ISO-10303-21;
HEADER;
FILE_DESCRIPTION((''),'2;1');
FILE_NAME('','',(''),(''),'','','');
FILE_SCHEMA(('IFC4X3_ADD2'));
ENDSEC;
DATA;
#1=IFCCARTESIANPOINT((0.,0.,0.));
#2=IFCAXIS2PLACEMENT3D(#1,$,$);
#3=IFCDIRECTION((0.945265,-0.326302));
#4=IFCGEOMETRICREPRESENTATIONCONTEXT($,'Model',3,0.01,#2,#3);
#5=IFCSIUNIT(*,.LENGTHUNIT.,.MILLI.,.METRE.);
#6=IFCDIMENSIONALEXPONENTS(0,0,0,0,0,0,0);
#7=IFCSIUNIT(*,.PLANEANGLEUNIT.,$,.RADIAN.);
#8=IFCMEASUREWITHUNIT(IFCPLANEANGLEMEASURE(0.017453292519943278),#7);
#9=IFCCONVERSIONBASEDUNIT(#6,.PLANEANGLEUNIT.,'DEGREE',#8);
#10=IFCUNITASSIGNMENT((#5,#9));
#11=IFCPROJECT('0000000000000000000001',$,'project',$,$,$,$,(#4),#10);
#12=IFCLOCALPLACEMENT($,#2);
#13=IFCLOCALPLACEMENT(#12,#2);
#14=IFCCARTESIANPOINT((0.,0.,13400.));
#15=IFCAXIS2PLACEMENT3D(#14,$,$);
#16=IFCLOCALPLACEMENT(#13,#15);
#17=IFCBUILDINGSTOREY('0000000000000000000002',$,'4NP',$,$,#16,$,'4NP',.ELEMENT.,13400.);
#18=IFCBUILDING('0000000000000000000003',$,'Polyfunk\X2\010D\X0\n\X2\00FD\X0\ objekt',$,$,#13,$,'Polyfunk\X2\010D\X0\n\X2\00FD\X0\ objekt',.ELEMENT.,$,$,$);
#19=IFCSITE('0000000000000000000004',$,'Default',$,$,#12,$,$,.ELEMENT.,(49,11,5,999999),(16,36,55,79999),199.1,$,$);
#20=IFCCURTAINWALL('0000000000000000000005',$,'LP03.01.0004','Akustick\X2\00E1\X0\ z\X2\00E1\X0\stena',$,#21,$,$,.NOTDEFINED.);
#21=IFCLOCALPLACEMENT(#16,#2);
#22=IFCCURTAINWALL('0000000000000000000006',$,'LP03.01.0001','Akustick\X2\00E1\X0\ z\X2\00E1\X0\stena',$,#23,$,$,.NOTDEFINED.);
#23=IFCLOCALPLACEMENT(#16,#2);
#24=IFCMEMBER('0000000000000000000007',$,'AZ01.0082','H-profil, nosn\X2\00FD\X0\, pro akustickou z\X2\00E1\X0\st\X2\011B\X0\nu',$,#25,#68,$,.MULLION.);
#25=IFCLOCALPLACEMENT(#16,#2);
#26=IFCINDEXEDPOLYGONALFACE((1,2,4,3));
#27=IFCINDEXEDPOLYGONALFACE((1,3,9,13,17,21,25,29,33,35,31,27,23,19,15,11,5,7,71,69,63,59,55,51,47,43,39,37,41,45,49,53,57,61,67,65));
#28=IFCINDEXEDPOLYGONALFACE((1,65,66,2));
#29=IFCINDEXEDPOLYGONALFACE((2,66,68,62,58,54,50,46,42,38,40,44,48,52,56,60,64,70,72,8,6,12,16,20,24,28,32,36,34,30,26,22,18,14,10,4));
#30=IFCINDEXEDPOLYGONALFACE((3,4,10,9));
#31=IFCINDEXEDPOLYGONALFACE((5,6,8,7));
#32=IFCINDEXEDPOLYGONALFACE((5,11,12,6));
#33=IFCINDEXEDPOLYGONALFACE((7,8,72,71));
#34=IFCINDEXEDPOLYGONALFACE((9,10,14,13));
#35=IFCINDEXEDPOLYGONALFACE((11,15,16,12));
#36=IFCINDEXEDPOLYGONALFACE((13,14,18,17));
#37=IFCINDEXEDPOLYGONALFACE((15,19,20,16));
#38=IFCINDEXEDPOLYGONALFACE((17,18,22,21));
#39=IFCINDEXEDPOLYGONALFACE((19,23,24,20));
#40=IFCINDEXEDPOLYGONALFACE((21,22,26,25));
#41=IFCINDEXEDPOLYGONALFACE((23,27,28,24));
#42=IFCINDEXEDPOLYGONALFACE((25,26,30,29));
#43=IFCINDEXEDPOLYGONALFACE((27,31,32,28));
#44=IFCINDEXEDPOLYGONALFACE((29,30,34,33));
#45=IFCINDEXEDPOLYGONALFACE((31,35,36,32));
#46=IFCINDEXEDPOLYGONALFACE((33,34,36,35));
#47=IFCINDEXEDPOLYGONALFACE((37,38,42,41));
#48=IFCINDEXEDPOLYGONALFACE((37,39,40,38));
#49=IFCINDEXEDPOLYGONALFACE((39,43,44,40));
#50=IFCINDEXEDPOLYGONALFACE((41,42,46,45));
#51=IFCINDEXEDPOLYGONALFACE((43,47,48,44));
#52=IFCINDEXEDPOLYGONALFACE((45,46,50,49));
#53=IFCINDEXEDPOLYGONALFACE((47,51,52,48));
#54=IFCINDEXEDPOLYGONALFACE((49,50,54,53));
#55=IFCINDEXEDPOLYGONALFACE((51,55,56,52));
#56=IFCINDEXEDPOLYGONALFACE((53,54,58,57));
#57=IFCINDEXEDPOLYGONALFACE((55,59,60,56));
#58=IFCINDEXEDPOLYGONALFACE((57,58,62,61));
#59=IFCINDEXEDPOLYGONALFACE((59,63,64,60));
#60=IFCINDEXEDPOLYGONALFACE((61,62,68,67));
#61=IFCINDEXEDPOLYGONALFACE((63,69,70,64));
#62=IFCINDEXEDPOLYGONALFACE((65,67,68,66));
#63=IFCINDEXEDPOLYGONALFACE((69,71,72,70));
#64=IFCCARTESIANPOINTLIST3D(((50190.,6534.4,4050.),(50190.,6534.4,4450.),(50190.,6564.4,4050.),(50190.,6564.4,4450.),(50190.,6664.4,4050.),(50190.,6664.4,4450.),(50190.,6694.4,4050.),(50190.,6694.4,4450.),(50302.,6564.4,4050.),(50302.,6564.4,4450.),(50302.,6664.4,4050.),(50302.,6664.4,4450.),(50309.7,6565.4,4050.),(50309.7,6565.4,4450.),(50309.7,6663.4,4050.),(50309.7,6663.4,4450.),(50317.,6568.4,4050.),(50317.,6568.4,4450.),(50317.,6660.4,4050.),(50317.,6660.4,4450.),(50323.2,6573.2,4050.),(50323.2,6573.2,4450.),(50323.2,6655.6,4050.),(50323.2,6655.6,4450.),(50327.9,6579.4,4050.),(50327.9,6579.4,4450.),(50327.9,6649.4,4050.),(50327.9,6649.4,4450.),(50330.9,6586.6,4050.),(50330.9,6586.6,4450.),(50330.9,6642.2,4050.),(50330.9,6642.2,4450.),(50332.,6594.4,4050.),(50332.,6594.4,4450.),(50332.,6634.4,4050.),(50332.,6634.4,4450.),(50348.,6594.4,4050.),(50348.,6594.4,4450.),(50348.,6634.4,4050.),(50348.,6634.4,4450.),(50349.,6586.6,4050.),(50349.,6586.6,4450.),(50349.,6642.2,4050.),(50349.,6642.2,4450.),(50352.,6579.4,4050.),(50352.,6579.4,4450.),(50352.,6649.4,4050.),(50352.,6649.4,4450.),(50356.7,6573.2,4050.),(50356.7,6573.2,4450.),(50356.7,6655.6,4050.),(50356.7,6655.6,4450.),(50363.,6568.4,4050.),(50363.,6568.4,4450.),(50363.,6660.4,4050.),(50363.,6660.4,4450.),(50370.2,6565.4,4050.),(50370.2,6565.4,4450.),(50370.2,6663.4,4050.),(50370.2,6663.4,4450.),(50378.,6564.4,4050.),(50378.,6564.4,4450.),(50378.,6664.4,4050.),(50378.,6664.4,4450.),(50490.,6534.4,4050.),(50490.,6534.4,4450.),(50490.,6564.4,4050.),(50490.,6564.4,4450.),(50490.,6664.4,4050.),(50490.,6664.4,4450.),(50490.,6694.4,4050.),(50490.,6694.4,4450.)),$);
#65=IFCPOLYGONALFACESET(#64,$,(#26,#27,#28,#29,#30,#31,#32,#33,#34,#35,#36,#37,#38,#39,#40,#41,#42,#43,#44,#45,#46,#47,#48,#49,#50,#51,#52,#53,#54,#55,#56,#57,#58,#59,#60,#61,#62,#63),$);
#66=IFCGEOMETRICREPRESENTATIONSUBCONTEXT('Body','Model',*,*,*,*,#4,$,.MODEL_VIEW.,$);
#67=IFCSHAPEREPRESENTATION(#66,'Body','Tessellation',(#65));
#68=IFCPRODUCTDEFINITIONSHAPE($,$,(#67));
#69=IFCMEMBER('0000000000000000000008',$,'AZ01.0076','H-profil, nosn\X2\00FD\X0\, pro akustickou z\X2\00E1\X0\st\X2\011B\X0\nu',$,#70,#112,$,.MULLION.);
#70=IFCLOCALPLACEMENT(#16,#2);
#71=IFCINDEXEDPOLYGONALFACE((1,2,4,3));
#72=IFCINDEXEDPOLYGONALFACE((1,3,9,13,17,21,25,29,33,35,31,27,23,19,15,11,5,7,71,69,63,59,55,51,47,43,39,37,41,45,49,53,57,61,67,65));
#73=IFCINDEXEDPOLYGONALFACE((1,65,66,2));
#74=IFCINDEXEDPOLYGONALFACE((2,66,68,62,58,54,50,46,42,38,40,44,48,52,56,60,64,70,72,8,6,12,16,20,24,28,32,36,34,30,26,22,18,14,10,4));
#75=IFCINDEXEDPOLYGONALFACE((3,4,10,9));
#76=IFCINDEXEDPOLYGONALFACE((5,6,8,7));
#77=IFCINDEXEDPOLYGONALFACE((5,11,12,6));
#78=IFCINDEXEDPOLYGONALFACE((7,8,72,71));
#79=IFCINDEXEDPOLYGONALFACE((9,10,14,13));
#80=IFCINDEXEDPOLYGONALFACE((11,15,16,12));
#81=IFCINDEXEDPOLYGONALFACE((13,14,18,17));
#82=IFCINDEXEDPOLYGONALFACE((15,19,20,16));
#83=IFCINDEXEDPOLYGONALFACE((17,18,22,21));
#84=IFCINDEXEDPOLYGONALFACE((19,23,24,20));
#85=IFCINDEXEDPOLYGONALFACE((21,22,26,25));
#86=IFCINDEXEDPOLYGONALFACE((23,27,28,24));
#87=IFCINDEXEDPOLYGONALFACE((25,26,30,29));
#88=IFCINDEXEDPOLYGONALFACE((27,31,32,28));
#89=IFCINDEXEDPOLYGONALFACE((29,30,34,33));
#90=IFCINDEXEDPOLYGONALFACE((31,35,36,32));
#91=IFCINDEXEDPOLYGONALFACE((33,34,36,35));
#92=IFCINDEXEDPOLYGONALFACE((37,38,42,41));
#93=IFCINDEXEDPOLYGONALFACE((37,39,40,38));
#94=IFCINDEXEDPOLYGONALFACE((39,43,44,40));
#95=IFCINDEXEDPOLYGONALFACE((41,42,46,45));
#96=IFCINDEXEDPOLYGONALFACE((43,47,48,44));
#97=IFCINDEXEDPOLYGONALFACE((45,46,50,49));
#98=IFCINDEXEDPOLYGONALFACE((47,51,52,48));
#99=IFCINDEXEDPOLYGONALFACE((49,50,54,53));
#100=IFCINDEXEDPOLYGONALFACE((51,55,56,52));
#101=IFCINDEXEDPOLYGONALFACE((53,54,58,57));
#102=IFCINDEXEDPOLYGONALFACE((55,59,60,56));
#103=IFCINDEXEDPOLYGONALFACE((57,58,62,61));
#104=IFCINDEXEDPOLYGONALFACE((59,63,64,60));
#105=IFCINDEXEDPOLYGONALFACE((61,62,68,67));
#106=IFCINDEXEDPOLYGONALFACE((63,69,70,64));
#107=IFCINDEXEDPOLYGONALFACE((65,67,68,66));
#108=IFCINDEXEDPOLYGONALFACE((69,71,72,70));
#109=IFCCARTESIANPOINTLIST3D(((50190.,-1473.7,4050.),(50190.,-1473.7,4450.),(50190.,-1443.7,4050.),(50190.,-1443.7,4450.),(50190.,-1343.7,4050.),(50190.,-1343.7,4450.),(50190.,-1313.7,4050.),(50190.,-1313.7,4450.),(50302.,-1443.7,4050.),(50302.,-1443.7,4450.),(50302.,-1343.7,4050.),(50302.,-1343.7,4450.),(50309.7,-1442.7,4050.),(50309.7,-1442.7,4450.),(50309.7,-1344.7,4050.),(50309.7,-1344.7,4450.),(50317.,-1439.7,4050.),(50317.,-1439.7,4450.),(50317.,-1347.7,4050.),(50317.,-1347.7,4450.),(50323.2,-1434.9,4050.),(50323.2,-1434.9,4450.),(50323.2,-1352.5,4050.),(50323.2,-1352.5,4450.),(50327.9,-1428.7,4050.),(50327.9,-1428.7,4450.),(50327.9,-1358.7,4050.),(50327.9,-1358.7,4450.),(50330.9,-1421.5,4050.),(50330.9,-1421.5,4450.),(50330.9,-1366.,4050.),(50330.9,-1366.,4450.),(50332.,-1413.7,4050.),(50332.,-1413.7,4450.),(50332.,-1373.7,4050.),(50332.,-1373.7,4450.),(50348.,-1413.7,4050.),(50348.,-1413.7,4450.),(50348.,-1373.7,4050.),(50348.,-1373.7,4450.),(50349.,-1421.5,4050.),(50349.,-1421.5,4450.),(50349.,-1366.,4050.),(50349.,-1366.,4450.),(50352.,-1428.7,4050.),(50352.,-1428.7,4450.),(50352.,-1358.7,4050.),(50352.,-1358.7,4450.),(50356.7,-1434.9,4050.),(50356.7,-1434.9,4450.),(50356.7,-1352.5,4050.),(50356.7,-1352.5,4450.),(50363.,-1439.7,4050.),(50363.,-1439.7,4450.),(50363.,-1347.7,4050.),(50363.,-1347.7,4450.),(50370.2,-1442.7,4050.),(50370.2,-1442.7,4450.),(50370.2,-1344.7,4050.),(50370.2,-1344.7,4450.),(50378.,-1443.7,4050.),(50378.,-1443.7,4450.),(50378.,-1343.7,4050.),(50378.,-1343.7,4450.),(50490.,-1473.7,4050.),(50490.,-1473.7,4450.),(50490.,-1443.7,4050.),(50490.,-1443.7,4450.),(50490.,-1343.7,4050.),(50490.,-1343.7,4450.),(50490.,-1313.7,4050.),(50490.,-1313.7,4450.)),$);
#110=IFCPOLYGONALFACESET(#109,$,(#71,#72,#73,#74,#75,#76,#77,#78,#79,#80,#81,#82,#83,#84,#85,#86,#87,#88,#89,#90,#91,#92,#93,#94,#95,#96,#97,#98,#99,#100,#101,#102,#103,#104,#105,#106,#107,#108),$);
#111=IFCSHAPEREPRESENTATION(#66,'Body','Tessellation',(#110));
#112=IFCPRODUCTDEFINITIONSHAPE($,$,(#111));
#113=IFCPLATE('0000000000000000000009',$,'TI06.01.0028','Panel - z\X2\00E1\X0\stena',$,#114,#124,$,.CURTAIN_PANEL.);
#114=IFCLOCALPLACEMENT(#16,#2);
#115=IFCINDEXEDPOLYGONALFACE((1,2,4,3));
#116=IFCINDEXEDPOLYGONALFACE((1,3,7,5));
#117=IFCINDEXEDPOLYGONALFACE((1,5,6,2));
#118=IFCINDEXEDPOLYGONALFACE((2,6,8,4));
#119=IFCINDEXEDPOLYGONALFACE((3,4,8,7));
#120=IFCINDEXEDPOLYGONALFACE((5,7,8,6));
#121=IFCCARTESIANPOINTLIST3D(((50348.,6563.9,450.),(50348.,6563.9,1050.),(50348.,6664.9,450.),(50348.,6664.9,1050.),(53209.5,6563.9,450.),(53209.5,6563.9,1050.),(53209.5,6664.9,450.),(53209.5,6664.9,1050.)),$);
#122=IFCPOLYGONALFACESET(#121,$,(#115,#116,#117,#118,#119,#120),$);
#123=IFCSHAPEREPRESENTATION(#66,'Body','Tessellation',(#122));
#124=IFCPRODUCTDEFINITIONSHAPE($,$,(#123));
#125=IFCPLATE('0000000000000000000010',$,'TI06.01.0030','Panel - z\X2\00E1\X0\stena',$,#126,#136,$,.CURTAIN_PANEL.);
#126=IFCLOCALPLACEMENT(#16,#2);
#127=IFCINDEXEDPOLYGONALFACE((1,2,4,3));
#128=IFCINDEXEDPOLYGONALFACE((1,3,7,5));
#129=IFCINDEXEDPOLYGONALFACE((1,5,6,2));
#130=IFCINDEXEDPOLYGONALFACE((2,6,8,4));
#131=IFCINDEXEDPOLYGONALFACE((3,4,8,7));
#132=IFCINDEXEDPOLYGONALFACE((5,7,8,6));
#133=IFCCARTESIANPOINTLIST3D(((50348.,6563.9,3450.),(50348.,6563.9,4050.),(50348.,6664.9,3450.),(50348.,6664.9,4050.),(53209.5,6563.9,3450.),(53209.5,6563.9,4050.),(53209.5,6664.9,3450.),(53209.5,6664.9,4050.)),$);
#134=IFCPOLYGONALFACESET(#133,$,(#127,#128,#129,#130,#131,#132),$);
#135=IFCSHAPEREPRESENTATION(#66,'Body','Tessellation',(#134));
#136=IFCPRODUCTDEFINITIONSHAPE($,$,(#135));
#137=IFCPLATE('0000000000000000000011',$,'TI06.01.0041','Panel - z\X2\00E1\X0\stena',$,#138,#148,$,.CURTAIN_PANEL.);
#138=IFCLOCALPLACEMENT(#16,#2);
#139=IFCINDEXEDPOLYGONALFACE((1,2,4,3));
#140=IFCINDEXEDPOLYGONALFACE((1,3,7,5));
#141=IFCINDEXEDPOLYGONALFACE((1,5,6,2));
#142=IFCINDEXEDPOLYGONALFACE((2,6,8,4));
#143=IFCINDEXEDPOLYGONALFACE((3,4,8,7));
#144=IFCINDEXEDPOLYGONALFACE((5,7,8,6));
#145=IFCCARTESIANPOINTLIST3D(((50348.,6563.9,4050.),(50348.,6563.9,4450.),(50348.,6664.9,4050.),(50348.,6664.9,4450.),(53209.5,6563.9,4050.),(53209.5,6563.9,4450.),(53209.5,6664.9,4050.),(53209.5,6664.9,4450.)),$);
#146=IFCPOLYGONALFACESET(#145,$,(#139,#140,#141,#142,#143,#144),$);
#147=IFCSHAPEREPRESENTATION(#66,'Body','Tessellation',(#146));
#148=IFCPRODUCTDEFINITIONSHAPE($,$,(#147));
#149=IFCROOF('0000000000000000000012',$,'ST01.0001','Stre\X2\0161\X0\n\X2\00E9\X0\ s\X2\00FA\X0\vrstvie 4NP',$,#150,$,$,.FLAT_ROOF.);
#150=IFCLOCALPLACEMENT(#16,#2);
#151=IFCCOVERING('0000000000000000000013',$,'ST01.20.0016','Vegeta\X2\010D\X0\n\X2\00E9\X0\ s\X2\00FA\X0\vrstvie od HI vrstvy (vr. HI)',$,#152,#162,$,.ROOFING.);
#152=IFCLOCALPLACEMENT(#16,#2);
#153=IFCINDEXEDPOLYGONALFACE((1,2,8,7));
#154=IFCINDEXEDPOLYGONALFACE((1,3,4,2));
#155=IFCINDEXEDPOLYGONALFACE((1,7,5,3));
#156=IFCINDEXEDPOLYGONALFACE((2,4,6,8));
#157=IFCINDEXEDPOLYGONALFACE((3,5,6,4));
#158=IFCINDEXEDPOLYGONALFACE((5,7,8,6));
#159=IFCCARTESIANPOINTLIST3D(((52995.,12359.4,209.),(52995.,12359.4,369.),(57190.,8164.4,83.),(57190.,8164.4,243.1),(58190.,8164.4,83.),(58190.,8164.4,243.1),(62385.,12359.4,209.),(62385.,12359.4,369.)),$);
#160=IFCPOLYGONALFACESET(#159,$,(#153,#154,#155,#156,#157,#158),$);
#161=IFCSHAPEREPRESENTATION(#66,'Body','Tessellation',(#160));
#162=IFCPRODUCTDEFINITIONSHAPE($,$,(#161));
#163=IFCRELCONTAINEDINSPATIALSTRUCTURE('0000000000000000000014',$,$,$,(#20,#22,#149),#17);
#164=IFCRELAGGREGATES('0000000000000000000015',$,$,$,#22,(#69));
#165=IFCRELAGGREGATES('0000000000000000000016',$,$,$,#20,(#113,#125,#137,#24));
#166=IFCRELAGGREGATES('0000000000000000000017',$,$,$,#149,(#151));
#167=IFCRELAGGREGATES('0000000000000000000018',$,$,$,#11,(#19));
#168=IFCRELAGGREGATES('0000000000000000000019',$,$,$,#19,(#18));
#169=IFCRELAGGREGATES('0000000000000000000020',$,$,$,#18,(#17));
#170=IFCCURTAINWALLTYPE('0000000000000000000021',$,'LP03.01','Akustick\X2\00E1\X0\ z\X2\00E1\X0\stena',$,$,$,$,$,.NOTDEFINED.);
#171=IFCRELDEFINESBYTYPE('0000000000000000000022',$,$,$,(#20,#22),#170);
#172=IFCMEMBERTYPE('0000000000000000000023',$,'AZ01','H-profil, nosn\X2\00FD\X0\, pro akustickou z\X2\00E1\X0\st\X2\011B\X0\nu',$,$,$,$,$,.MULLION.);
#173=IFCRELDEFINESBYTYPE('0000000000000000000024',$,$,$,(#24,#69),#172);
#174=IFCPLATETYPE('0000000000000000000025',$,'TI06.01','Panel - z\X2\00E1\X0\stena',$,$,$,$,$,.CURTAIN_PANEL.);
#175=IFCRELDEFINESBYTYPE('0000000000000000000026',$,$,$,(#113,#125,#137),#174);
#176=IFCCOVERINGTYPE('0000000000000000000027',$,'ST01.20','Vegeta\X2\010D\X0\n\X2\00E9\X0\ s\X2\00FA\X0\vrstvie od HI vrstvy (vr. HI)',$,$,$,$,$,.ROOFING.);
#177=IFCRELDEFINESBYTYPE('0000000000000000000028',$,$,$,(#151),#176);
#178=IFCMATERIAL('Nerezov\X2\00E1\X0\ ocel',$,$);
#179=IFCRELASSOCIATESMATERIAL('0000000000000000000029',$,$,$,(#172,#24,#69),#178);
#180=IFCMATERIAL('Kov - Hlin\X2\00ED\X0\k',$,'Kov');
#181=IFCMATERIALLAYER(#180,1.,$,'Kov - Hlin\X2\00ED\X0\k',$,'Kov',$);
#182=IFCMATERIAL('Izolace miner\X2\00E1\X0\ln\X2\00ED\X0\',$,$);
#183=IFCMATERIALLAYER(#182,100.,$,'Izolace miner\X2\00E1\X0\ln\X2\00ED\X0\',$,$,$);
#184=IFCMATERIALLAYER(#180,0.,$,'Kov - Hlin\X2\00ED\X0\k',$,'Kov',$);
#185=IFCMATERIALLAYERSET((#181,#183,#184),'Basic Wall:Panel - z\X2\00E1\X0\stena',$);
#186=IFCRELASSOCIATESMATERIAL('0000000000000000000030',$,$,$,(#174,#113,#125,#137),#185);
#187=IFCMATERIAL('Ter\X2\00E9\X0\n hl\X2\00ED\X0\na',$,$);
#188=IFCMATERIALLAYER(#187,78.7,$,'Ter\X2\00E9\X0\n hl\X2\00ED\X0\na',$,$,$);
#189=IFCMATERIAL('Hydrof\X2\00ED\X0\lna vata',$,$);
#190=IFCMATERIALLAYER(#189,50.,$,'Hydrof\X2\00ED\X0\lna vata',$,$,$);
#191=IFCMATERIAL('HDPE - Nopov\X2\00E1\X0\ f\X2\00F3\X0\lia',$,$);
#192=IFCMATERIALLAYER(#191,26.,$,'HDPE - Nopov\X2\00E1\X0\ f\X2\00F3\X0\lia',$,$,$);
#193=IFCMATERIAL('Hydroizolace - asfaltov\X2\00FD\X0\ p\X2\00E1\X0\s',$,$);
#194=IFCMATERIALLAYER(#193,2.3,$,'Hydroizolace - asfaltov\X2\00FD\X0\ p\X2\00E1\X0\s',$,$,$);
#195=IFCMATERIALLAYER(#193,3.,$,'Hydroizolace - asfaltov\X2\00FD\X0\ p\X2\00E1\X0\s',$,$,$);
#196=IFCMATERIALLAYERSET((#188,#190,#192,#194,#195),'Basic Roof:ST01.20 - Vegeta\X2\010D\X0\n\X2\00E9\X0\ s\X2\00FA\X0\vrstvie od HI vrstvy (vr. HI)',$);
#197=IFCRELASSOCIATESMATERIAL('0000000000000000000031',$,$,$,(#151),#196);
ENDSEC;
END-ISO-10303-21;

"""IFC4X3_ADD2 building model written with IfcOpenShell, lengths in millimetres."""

from ifc_helpers import new_model, entity, si_unit, converted_unit, direction, frame, frame_2d, origin, origin_2d_with_axis, place, context, subcontext, project, spatial, polyline, circle_curve, parameter, trimmed, segment, composite_curve, rectangle, outline, extrude, source, transform, mapped, material, layer, layer_set, layer_usage, material_profile, profile_set, profile_usage, type_object, element, aggregate, save


model = new_model("IFC4X3_ADD2")

# Units and contexts
model_context = context("Model", 3, precision=0.01, world=origin(), true_north=direction((0.945265, -0.326302)))
body_context = subcontext(model_context, "Body", "Model", "MODEL_VIEW")
ifc_project = project(units=[si_unit("LENGTHUNIT", "METRE", prefix="MILLI"), converted_unit("PLANEANGLEUNIT", "DEGREE", entity("IfcPlaneAngleMeasure", 0.017453292519943278), si_unit("PLANEANGLEUNIT", "RADIAN"), dimensions=[0, 0, 0, 0, 0, 0, 0])], contexts=[model_context])

# Site, building, storey
site_placement = place(None, origin())
site = spatial("IfcSite", under=ifc_project, at=site_placement, Name="Default", CompositionType="ELEMENT", RefLatitude=(49, 11, 5, 999999), RefLongitude=(16, 36, 55, 79999), RefElevation=199.1)
building_placement = place(site_placement, origin())
building = spatial("IfcBuilding", under=site, at=building_placement, Name="Polyfunkčný objekt", LongName="Polyfunkčný objekt", CompositionType="ELEMENT")
storey_placement = place(building_placement, frame((0.0, 0.0, 13400.0)))
storey = spatial("IfcBuildingStorey", under=building, at=storey_placement, Name="4NP", LongName="4NP", CompositionType="ELEMENT", Elevation=13400.0)

# Curtain walls
curtain_wall_type = type_object("IfcCurtainWallType", Name="LP03.01", Description="Akustická zástena", PredefinedType="NOTDEFINED")
curtain_wall_1_placement = place(storey_placement, frame((0.0, 0.0, -13400.0)))
curtain_wall_1 = element("IfcCurtainWall", 1, at=curtain_wall_1_placement, inside=storey, type_object=curtain_wall_type, Name="LP03.01.0004", Description="Akustická zástena", PredefinedType="NOTDEFINED")
ifc_material_1 = material(Name="Nerezová ocel")
ifc_material_profile = material_profile(ifc_material_1, outline(composite_curve([segment(polyline([(50.0, -150.0), (80.0, -150.0)]), True, "CONTINUOUS"), segment(polyline([(80.0, -150.0), (80.0, 150.0)]), True, "CONTINUOUS"), segment(polyline([(80.0, 150.0), (50.0, 150.0)]), True, "CONTINUOUS"), segment(polyline([(50.0, 150.0), (50.0, 38.0)]), True, "CONTINUOUS"), segment(trimmed(circle_curve(frame_2d((20.0, 38.0), x_axis=(0.0, 1.0)), 30.0), [parameter(180.0)], [parameter(270.0)], True, "PARAMETER"), False, "CONTINUOUS"), segment(polyline([(20.0, 8.0), (-20.0, 8.0)]), True, "CONTINUOUS"), segment(trimmed(circle_curve(frame_2d((-20.0, 38.0), x_axis=(0.0, 1.0)), 30.0), [parameter(90.0)], [parameter(180.0)], True, "PARAMETER"), False, "CONTINUOUS"), segment(polyline([(-50.0, 38.0), (-50.0, 150.0)]), True, "CONTINUOUS"), segment(polyline([(-50.0, 150.0), (-80.0, 150.0)]), True, "CONTINUOUS"), segment(polyline([(-80.0, 150.0), (-80.0, -150.0)]), True, "CONTINUOUS"), segment(polyline([(-80.0, -150.0), (-50.0, -150.0)]), True, "CONTINUOUS"), segment(polyline([(-50.0, -150.0), (-50.0, -38.0)]), True, "CONTINUOUS"), segment(trimmed(circle_curve(frame_2d((-20.0, -38.0), x_axis=(0.0, 1.0)), 30.0), [parameter(0.0)], [parameter(90.0)], True, "PARAMETER"), False, "CONTINUOUS"), segment(polyline([(-20.0, -8.0), (20.0, -8.0)]), True, "CONTINUOUS"), segment(trimmed(circle_curve(frame_2d((20.0, -38.0), x_axis=(0.0, 1.0)), 30.0), [parameter(270.0)], [parameter(0.0)], True, "PARAMETER"), False, "CONTINUOUS"), segment(polyline([(50.0, -38.0), (50.0, -150.0)]), True, "CONTINUOUS")], self_intersect=False)), Name="Profil zástena")
ifc_profile_set = profile_set([ifc_material_profile], Name="Profil zástena")
ifc_profile_usage = profile_usage(ifc_profile_set)
member_type = type_object("IfcMemberType", Name="AZ01", Description="H-profil, nosný, pro akustickou zástěnu", PredefinedType="MULLION", material=ifc_profile_set)
curtain_wall_2_placement = place(storey_placement, frame((0.0, 0.0, -13400.0)))
curtain_wall_2 = element("IfcCurtainWall", 2, at=curtain_wall_2_placement, inside=storey, type_object=curtain_wall_type, Name="LP03.01.0001", Description="Akustická zástena", PredefinedType="NOTDEFINED")

# Members
shared_shape_1 = source(origin(), body_context, "Body", "SweptSolid", [
    extrude(outline(composite_curve([segment(polyline([(-150.0, -50.0), (-150.0, -80.0)]), True, "CONTINUOUS"), segment(polyline([(-150.0, -80.0), (150.0, -80.0)]), True, "CONTINUOUS"), segment(polyline([(150.0, -80.0), (150.0, -50.0)]), True, "CONTINUOUS"), segment(polyline([(150.0, -50.0), (38.0, -50.0)]), True, "CONTINUOUS"), segment(trimmed(circle_curve(frame_2d((38.0, -20.0), x_axis=(1.0, 0.0)), 30.0), [parameter(180.0)], [parameter(270.0)], True, "PARAMETER"), False, "CONTINUOUS"), segment(polyline([(8.0, -20.0), (8.0, 20.0)]), True, "CONTINUOUS"), segment(trimmed(circle_curve(frame_2d((38.0, 20.0), x_axis=(1.0, 0.0)), 30.0), [parameter(90.0)], [parameter(180.0)], True, "PARAMETER"), False, "CONTINUOUS"), segment(polyline([(38.0, 50.0), (150.0, 50.0)]), True, "CONTINUOUS"), segment(polyline([(150.0, 50.0), (150.0, 80.0)]), True, "CONTINUOUS"), segment(polyline([(150.0, 80.0), (-150.0, 80.0)]), True, "CONTINUOUS"), segment(polyline([(-150.0, 80.0), (-150.0, 50.0)]), True, "CONTINUOUS"), segment(polyline([(-150.0, 50.0), (-38.0, 50.0)]), True, "CONTINUOUS"), segment(trimmed(circle_curve(frame_2d((-38.0, 20.0), x_axis=(1.0, 0.0)), 30.0), [parameter(0.0)], [parameter(90.0)], True, "PARAMETER"), False, "CONTINUOUS"), segment(polyline([(-8.0, 20.0), (-8.0, -20.0)]), True, "CONTINUOUS"), segment(trimmed(circle_curve(frame_2d((-38.0, -20.0), x_axis=(1.0, 0.0)), 30.0), [parameter(270.0)], [parameter(0.0)], True, "PARAMETER"), False, "CONTINUOUS"), segment(polyline([(-38.0, -50.0), (-150.0, -50.0)]), True, "CONTINUOUS")], self_intersect=False)), frame((-150.0, 0.0, -400.0), z_axis=(0.0, 0.0, -1.0), x_axis=(-1.0, 0.0, 0.0)), (0.0, 0.0, -1.0), 400.0),
])
member_1_placement = place(curtain_wall_1_placement, frame((50190.0, 6614.4, 17850.0), z_axis=(0.0, 0.0, 1.0), x_axis=(-1.0, 0.0, 0.0)))
member_1 = element("IfcMember", 3, at=member_1_placement, type_object=member_type, material=ifc_profile_usage, Name="AZ01.0082", Description="H-profil, nosný, pro akustickou zástěnu", PredefinedType="MULLION", context=body_context, shape_type="MappedRepresentation", body=[
    mapped(shared_shape_1, transform((0.0, 0.0, 0.0), scale=1.0)),
])
member_2_placement = place(curtain_wall_2_placement, frame((50190.0, -1393.7, 17850.0), z_axis=(0.0, 0.0, 1.0), x_axis=(-1.0, 0.0, 0.0)))
member_2 = element("IfcMember", 4, at=member_2_placement, type_object=member_type, material=ifc_profile_usage, Name="AZ01.0076", Description="H-profil, nosný, pro akustickou zástěnu", PredefinedType="MULLION", context=body_context, shape_type="MappedRepresentation", body=[
    mapped(shared_shape_1, transform((0.0, 0.0, 0.0), scale=1.0)),
])
aggregate(curtain_wall_2, [member_2])

# Plates
ifc_material_2 = material(Name="Kov - Hliník", Category="Kov")
ifc_layer_1 = layer(ifc_material_2, 1.0, Name="Kov - Hliník", Category="Kov")
ifc_material_3 = material(Name="Izolace minerální")
ifc_layer_2 = layer(ifc_material_3, 100.0, Name="Izolace minerální")
ifc_layer_3 = layer(ifc_material_2, 0.0, Name="Kov - Hliník", Category="Kov")
ifc_layer_set_1 = layer_set([ifc_layer_1, ifc_layer_2, ifc_layer_3], Name="Basic Wall:Panel - zástena")
ifc_layer_usage_1 = layer_usage(ifc_layer_set_1, "AXIS2", "POSITIVE", -50.5)
plate_type = type_object("IfcPlateType", Name="TI06.01", Description="Panel - zástena", PredefinedType="CURTAIN_PANEL", material=ifc_layer_set_1)
plate_1_placement = place(storey_placement, frame((50348.0, 6614.4, 450.0)))
plate_1 = element("IfcPlate", 5, at=plate_1_placement, type_object=plate_type, material=ifc_layer_usage_1, Name="TI06.01.0028", Description="Panel - zástena", PredefinedType="CURTAIN_PANEL", context=body_context, shape_type="SweptSolid", body=[
    extrude(rectangle(XDim=101.0, YDim=2861.5, at=frame_2d((0.0, 0.0), x_axis=(1.0, 0.0))), frame((1430.7, 0.0, 0.0), z_axis=(0.0, 0.0, 1.0), x_axis=(0.0, 1.0, 0.0)), (0.0, 0.0, 1.0), 600.0),
])
ifc_layer_usage_2 = layer_usage(ifc_layer_set_1, "AXIS2", "POSITIVE", -50.5)
plate_2_placement = place(storey_placement, frame((50348.0, 6614.4, 3450.0)))
plate_2 = element("IfcPlate", 6, at=plate_2_placement, type_object=plate_type, material=ifc_layer_usage_2, Name="TI06.01.0030", Description="Panel - zástena", PredefinedType="CURTAIN_PANEL", context=body_context, shape_type="SweptSolid", body=[
    extrude(rectangle(XDim=101.0, YDim=2861.5, at=frame_2d((0.0, 0.0), x_axis=(1.0, 0.0))), frame((1430.7, 0.0, 0.0), z_axis=(0.0, 0.0, 1.0), x_axis=(0.0, 1.0, 0.0)), (0.0, 0.0, 1.0), 600.0),
])
ifc_layer_usage_3 = layer_usage(ifc_layer_set_1, "AXIS2", "POSITIVE", -50.5)
plate_3_placement = place(storey_placement, frame((50348.0, 6614.4, 4050.0)))
plate_3 = element("IfcPlate", 7, at=plate_3_placement, type_object=plate_type, material=ifc_layer_usage_3, Name="TI06.01.0041", Description="Panel - zástena", PredefinedType="CURTAIN_PANEL", context=body_context, shape_type="SweptSolid", body=[
    extrude(rectangle(XDim=101.0, YDim=2861.5, at=origin_2d_with_axis()), frame((1430.7, 0.0, 0.0), z_axis=(0.0, 0.0, 1.0), x_axis=(0.0, 1.0, 0.0)), (0.0, 0.0, 1.0), 400.0),
])
aggregate(curtain_wall_1, [plate_1, plate_2, plate_3, member_1])

# Roof, covering
roof = element("IfcRoof", 8, inside=storey, Name="ST01.0001", Description="Strešné súvrstvie 4NP", PredefinedType="FLAT_ROOF")
ifc_material_4 = material(Name="Terén hlína")
ifc_layer_4 = layer(ifc_material_4, 78.7, Name="Terén hlína")
ifc_material_5 = material(Name="Hydrofílna vata")
ifc_layer_5 = layer(ifc_material_5, 50.0, Name="Hydrofílna vata")
ifc_material_6 = material(Name="HDPE - Nopová fólia")
ifc_layer_6 = layer(ifc_material_6, 26.0, Name="HDPE - Nopová fólia")
ifc_material_7 = material(Name="Hydroizolace - asfaltový pás")
ifc_layer_7 = layer(ifc_material_7, 2.3, Name="Hydroizolace - asfaltový pás")
ifc_layer_8 = layer(ifc_material_7, 3.0, Name="Hydroizolace - asfaltový pás")
ifc_layer_set_2 = layer_set([ifc_layer_4, ifc_layer_5, ifc_layer_6, ifc_layer_7, ifc_layer_8], Name="Basic Roof:ST01.20 - Vegetačné súvrstvie od HI vrstvy (vr. HI)")
covering_type_1 = type_object("IfcCoveringType", Name="ST01.20", Description="Vegetačné súvrstvie od HI vrstvy (vr. HI)", PredefinedType="ROOFING")
placement_1 = place(storey_placement, frame((52995.0, 8164.4, 83.0)))
covering_1_placement = place(placement_1, origin())
covering_1 = element("IfcCovering", 9, at=covering_1_placement, type_object=covering_type_1, material=ifc_layer_set_2, Name="ST01.20.0016", Description="Vegetačné súvrstvie od HI vrstvy (vr. HI)", PredefinedType="ROOFING", context=body_context, shape_type="SweptSolid", body=[
    extrude(outline(polyline([(500.0, -2098.4), (4695.0, 2098.4), (-4695.0, 2098.4), (-500.0, -2098.4), (500.0, -2098.4)])), frame((4695.0, 2097.5, 63.0), z_axis=(0.0, -0.030015, 0.999549), x_axis=(1.0, 0.0, 0.0)), (0.0, 0.030015, 0.999549), 160.1),
])
aggregate(roof, [covering_1])

save(model, "model.ifc")
